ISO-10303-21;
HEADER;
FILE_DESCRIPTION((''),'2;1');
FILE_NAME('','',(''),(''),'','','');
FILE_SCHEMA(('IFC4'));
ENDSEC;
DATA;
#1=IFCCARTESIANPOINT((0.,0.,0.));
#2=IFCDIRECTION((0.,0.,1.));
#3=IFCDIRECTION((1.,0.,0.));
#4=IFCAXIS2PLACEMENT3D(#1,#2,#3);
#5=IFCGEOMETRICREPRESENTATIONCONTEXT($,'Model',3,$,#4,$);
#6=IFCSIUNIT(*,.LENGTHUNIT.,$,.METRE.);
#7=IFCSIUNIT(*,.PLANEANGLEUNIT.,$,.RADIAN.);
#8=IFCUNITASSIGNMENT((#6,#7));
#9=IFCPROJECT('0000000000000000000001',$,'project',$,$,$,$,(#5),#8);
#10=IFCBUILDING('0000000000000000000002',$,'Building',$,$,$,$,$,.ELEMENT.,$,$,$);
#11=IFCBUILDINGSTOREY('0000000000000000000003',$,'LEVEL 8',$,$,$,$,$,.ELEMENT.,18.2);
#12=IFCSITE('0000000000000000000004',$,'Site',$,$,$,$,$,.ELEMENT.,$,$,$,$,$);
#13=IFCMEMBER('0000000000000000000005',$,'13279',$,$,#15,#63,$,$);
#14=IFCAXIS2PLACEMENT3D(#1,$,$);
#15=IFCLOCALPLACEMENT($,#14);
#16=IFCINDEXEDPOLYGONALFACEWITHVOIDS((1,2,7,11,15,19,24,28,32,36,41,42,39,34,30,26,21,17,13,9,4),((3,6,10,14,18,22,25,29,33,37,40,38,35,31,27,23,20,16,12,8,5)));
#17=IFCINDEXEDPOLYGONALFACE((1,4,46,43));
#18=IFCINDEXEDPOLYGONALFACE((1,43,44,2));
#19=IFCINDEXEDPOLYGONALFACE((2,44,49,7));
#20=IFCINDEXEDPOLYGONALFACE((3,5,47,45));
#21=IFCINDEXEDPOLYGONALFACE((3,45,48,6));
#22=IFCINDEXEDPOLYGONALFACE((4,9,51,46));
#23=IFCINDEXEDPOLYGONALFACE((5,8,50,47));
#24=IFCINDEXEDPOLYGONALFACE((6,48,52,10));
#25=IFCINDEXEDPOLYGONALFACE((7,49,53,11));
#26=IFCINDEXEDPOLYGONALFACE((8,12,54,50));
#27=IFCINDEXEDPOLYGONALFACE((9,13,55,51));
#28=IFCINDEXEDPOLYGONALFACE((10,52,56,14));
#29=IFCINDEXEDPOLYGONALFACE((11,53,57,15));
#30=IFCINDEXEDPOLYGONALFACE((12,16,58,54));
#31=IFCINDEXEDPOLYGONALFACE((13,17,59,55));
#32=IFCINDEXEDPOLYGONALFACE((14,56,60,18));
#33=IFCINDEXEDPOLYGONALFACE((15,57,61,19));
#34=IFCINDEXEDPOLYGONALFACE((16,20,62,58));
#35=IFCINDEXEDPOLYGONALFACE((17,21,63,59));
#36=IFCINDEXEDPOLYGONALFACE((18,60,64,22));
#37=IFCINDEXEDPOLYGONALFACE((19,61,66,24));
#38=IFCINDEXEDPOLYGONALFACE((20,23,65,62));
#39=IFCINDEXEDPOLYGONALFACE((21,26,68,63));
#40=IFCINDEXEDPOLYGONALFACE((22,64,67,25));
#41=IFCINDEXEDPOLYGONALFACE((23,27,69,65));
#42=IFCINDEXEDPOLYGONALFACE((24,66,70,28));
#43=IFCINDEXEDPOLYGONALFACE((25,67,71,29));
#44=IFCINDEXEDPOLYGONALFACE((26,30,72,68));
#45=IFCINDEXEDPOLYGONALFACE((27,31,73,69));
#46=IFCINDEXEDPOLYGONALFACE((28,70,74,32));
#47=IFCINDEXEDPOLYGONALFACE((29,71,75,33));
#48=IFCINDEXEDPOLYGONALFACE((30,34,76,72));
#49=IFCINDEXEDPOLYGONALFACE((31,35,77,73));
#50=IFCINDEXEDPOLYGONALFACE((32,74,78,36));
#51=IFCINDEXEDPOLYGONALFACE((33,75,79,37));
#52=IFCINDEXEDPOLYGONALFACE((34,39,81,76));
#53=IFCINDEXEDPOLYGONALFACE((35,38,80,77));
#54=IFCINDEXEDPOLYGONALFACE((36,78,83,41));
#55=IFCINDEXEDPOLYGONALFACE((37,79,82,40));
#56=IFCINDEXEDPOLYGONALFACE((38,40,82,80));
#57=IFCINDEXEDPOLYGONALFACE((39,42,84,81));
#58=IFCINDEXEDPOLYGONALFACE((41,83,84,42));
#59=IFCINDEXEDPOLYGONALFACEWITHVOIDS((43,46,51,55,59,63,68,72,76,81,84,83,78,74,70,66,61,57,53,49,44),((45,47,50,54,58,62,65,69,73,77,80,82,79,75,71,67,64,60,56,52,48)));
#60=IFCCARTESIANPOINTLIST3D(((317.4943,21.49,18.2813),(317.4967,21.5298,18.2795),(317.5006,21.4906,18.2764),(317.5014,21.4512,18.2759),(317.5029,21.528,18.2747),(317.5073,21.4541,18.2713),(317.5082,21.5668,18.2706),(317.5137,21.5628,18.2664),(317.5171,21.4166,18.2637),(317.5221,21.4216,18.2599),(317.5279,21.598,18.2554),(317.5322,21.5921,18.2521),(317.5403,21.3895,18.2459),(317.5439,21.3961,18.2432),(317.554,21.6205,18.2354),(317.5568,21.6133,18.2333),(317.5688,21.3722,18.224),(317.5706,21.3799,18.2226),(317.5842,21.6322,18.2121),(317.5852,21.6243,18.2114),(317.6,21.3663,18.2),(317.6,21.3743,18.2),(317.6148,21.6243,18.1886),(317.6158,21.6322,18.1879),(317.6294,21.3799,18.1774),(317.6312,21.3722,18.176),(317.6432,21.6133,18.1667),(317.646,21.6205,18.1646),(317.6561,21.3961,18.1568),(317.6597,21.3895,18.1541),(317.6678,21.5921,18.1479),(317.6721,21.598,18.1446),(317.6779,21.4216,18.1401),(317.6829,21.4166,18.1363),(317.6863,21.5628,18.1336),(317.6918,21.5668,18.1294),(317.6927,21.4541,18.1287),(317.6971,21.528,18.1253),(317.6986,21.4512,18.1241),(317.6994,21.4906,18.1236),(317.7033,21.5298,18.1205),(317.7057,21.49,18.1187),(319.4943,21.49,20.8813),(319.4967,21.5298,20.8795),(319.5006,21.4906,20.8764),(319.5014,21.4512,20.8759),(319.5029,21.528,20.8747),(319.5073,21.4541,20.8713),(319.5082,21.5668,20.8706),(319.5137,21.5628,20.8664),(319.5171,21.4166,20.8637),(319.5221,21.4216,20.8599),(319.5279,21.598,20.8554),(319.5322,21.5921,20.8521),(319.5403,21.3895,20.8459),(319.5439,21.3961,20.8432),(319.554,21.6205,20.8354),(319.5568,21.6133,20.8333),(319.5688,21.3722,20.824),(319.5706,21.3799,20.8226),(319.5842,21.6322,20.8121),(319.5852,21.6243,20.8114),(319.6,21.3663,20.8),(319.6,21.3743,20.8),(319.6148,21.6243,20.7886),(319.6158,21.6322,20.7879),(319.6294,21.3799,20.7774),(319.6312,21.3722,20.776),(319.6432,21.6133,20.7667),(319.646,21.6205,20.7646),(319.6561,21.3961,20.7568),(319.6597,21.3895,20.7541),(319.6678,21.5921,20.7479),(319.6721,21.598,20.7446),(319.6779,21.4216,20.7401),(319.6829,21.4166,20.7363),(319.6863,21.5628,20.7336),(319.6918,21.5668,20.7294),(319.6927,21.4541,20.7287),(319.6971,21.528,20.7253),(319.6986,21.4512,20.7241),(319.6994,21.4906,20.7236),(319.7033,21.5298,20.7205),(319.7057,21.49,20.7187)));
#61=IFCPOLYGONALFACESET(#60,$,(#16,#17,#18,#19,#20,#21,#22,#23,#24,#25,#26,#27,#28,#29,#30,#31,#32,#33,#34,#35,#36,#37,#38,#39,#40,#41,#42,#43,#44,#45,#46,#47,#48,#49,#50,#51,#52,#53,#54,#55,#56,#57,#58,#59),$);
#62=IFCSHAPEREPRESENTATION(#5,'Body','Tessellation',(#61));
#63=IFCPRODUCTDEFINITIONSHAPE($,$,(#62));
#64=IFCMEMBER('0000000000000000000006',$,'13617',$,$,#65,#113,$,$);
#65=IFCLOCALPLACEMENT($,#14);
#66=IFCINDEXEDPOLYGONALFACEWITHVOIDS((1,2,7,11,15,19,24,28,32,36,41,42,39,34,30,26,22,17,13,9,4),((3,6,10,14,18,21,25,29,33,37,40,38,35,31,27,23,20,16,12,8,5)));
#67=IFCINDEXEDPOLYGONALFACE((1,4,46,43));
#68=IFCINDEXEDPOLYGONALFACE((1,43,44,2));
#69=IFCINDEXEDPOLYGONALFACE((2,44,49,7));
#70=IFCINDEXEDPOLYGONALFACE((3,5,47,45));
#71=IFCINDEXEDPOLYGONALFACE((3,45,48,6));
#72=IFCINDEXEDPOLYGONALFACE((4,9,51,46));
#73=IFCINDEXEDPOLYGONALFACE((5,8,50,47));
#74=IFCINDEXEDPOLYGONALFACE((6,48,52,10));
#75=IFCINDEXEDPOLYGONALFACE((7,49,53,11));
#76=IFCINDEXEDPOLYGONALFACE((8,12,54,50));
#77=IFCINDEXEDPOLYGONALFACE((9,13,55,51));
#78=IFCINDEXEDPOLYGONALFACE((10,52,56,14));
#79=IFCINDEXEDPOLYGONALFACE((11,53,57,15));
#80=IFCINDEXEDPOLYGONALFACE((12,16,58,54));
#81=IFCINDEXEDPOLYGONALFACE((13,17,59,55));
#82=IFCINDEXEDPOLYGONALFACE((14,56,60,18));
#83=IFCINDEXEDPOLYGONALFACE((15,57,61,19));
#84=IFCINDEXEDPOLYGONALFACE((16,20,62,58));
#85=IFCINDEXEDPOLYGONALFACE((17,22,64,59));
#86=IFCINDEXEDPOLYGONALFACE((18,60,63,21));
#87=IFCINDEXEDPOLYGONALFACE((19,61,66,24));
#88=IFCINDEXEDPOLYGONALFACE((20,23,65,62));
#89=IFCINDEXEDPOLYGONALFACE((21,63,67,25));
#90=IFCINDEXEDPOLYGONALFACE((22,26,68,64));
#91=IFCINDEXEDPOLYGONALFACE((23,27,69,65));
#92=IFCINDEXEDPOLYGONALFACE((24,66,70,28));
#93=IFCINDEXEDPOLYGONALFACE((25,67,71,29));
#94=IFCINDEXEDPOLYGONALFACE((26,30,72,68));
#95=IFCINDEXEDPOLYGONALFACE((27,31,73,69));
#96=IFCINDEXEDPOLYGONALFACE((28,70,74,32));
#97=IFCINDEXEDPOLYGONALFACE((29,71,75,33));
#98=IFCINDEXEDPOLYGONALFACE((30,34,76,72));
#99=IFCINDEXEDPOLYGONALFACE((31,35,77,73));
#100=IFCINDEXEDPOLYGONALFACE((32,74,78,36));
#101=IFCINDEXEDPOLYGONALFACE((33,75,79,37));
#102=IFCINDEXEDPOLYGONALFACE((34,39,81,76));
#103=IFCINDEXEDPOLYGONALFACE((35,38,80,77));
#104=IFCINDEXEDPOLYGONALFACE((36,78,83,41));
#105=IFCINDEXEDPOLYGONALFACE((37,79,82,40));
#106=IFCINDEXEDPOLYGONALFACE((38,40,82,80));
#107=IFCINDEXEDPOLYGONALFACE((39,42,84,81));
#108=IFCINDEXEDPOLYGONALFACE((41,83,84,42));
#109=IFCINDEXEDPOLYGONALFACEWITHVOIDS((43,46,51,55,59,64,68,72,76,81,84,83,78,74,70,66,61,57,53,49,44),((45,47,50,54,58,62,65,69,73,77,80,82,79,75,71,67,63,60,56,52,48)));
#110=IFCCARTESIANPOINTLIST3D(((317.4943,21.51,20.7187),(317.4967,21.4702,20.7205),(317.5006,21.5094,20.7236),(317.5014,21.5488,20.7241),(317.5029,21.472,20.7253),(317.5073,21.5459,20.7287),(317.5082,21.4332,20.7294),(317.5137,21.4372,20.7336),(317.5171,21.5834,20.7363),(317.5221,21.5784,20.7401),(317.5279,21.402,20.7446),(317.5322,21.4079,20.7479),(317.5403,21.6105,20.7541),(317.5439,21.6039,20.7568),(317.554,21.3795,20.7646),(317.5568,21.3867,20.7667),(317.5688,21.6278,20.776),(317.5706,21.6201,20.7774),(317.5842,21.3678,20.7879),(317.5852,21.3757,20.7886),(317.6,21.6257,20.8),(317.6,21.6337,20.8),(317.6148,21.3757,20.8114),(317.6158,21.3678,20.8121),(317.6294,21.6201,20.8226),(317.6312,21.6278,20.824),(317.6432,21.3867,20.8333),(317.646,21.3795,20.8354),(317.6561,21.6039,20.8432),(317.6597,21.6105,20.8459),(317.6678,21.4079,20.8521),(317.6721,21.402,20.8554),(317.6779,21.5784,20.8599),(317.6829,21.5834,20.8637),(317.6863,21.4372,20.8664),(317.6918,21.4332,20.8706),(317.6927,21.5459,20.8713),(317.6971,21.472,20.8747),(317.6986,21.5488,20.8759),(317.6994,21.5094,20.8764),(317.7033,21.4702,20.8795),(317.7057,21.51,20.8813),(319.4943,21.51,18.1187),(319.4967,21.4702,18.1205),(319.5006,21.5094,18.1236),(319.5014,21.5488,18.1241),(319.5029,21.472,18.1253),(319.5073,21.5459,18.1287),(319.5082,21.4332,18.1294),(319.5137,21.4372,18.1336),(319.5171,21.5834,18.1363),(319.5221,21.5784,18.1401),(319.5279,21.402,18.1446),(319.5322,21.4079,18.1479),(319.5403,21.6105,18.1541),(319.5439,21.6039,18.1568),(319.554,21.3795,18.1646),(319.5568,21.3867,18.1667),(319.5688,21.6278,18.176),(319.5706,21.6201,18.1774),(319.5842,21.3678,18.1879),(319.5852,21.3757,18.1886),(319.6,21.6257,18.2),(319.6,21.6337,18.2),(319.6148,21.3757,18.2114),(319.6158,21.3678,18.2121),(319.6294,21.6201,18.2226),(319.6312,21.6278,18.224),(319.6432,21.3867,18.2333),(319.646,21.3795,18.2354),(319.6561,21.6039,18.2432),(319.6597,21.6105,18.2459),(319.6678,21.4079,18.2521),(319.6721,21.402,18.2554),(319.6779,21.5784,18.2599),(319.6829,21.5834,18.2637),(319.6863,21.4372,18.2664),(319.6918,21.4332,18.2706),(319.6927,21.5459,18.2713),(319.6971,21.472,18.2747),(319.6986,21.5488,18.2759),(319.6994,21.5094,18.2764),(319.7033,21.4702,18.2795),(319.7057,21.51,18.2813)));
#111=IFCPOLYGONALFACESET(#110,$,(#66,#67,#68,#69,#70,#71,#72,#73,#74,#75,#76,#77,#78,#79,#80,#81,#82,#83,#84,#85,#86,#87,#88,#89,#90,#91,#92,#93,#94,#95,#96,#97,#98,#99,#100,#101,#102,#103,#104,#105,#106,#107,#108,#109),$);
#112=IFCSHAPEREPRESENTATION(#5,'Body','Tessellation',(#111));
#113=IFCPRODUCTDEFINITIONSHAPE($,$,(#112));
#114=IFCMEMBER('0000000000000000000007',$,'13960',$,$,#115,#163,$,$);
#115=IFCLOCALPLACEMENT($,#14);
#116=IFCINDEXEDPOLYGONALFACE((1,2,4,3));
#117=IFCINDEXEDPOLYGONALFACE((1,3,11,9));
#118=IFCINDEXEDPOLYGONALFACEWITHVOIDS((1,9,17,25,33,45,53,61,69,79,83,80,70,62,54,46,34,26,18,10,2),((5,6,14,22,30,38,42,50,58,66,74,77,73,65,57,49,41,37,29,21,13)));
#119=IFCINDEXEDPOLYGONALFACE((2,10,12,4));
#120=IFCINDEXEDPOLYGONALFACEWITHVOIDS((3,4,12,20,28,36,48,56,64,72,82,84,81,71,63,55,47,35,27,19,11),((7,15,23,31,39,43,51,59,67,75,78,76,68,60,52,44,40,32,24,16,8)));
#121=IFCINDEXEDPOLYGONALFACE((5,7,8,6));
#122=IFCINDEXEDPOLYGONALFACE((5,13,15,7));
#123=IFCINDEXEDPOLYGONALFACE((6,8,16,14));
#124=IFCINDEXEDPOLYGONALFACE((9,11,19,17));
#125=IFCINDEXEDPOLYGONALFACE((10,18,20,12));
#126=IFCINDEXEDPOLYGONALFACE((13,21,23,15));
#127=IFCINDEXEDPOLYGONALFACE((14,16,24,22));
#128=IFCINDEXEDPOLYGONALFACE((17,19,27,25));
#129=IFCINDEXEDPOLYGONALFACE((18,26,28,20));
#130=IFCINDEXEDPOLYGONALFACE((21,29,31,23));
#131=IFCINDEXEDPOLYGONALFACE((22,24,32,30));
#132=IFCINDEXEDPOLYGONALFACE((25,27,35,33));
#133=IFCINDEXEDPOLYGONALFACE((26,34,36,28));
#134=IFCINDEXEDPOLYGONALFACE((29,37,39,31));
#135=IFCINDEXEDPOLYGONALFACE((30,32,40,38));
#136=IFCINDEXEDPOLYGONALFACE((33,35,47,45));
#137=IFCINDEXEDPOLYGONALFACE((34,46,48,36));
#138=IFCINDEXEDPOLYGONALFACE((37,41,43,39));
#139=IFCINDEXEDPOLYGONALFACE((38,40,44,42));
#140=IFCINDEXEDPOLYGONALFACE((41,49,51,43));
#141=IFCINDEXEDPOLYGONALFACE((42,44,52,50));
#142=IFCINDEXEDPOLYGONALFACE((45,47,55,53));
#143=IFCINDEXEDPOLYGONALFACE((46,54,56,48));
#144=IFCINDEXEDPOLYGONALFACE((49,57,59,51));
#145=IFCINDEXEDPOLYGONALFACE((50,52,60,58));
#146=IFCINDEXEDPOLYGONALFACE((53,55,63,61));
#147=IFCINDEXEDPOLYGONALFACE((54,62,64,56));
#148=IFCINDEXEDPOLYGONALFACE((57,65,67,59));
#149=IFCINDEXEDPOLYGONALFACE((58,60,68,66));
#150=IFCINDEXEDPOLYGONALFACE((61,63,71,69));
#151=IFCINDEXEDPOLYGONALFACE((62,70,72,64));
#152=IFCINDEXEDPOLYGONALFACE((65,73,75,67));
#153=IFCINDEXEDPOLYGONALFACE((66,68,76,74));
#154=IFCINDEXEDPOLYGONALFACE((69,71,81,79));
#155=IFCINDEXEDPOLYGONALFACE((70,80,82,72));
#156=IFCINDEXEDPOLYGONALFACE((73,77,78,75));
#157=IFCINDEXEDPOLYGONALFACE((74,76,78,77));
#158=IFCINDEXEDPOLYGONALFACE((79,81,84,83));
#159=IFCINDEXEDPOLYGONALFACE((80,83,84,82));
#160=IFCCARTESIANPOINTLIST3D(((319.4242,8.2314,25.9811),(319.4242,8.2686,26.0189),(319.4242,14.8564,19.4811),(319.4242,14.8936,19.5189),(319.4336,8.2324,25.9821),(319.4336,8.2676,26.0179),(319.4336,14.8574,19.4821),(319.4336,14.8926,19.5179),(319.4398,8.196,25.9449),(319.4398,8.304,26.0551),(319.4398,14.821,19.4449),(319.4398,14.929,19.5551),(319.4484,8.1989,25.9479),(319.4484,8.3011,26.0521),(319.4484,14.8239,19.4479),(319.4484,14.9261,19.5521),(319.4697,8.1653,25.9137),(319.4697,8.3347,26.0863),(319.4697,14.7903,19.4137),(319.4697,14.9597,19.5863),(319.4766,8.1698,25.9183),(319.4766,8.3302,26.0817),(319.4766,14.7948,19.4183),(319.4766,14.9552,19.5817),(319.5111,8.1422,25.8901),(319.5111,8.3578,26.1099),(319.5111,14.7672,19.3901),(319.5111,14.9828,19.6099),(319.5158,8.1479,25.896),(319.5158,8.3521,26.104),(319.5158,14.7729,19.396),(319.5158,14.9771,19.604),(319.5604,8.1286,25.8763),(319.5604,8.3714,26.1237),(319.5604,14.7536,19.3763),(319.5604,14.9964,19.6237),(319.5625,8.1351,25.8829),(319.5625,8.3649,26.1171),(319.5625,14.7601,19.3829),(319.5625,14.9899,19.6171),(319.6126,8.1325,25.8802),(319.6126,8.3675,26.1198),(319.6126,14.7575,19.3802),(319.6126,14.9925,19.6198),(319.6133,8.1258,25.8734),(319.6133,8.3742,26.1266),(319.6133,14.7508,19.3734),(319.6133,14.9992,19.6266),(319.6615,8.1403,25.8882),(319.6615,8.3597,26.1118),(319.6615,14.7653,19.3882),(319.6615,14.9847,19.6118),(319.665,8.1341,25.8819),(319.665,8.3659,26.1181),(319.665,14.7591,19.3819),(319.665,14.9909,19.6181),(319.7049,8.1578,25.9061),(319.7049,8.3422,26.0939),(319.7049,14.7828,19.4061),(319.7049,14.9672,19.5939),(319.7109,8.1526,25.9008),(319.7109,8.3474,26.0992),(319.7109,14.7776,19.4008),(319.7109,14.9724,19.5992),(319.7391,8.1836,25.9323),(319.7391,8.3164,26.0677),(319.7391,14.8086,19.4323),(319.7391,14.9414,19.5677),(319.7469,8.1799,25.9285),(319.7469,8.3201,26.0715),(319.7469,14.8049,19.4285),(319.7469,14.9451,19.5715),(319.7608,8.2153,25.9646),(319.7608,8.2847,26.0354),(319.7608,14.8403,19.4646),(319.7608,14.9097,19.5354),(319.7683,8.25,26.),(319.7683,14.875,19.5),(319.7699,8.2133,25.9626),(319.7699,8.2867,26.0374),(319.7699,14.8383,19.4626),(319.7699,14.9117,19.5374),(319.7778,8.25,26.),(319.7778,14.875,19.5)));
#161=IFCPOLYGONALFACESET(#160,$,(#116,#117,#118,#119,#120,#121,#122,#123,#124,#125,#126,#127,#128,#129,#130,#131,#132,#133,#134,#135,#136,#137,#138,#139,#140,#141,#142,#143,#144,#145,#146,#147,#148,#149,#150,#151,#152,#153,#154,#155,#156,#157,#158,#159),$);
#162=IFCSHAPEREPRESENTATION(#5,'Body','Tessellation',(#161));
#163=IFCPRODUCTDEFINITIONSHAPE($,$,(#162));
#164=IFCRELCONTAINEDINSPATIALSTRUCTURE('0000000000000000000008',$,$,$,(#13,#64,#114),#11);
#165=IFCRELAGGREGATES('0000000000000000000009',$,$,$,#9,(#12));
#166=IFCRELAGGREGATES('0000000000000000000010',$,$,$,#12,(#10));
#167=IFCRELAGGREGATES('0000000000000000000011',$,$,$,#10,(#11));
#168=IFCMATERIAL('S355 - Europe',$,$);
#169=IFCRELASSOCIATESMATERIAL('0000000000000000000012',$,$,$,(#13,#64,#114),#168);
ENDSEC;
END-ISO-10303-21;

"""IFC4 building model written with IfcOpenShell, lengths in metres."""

from ifc_helpers import new_model, si_unit, frame, origin_with_axes, origin_2d_with_axis, place, context, project, spatial, hollow_circle, extrude, material, material_profile, profile_set, profile_usage, element, save


model = new_model("IFC4")

# Units and contexts
model_context = context("Model", 3, world=origin_with_axes())
ifc_project = project(units=[si_unit("LENGTHUNIT", "METRE"), si_unit("PLANEANGLEUNIT", "RADIAN")], contexts=[model_context])

# Site, building, storey
site = spatial("IfcSite", under=ifc_project, Name="Site", CompositionType="ELEMENT")
building = spatial("IfcBuilding", under=site, Name="Building", CompositionType="ELEMENT")
storey = spatial("IfcBuildingStorey", under=building, Name="LEVEL 8", CompositionType="ELEMENT", Elevation=18.2)

# Shared definitions
ifc_material = material(Name="S355 - Europe")

# Members
ifc_material_profile_1 = material_profile(ifc_material, hollow_circle(Radius=0.1337, WallThickness=0.008, at=origin_2d_with_axis()))
ifc_profile_set_1 = profile_set([ifc_material_profile_1])
ifc_profile_usage_1 = profile_usage(ifc_profile_set_1, cardinal=10)
member_1_placement = place(None, frame((319.6, 21.5, 20.8), z_axis=(-0.609711, 0.0, -0.792624), x_axis=(0.0, -1.0, 0.0)))
element("IfcMember", 1, at=member_1_placement, inside=storey, material=ifc_profile_usage_1, Name="13279", context=model_context, shape_type="SweptSolid", body=[
    extrude(hollow_circle(Radius=0.1337, WallThickness=0.008, at=origin_2d_with_axis()), origin_with_axes(), (0.0, 0.0, 1.0), 3.2802),
])
ifc_material_profile_2 = material_profile(ifc_material, hollow_circle(Radius=0.1337, WallThickness=0.008, at=origin_2d_with_axis()))
ifc_profile_set_2 = profile_set([ifc_material_profile_2])
ifc_profile_usage_2 = profile_usage(ifc_profile_set_2, cardinal=10)
member_2_placement = place(None, frame((317.6, 21.5, 20.8), z_axis=(0.609711, 0.0, -0.792624), x_axis=(0.0, 1.0, 0.0)))
element("IfcMember", 2, at=member_2_placement, inside=storey, material=ifc_profile_usage_2, Name="13617", context=model_context, shape_type="SweptSolid", body=[
    extrude(hollow_circle(Radius=0.1337, WallThickness=0.008, at=origin_2d_with_axis()), origin_with_axes(), (0.0, 0.0, 1.0), 3.2802),
])
ifc_material_profile_3 = material_profile(ifc_material, hollow_circle(Radius=0.1778, WallThickness=0.0095, at=origin_2d_with_axis()))
ifc_profile_set_3 = profile_set([ifc_material_profile_3])
ifc_profile_usage_3 = profile_usage(ifc_profile_set_3, cardinal=10)
member_3_placement = place(None, frame((319.6, 14.875, 19.5), z_axis=(0.0, -0.713809, 0.700341), x_axis=(1.0, 0.0, 0.0)))
element("IfcMember", 3, at=member_3_placement, inside=storey, material=ifc_profile_usage_3, Name="13960", context=model_context, shape_type="SweptSolid", body=[
    extrude(hollow_circle(Radius=0.1778, WallThickness=0.0095, at=origin_2d_with_axis()), origin_with_axes(), (0.0, 0.0, 1.0), 9.2812),
])

save(model, "model.ifc")
